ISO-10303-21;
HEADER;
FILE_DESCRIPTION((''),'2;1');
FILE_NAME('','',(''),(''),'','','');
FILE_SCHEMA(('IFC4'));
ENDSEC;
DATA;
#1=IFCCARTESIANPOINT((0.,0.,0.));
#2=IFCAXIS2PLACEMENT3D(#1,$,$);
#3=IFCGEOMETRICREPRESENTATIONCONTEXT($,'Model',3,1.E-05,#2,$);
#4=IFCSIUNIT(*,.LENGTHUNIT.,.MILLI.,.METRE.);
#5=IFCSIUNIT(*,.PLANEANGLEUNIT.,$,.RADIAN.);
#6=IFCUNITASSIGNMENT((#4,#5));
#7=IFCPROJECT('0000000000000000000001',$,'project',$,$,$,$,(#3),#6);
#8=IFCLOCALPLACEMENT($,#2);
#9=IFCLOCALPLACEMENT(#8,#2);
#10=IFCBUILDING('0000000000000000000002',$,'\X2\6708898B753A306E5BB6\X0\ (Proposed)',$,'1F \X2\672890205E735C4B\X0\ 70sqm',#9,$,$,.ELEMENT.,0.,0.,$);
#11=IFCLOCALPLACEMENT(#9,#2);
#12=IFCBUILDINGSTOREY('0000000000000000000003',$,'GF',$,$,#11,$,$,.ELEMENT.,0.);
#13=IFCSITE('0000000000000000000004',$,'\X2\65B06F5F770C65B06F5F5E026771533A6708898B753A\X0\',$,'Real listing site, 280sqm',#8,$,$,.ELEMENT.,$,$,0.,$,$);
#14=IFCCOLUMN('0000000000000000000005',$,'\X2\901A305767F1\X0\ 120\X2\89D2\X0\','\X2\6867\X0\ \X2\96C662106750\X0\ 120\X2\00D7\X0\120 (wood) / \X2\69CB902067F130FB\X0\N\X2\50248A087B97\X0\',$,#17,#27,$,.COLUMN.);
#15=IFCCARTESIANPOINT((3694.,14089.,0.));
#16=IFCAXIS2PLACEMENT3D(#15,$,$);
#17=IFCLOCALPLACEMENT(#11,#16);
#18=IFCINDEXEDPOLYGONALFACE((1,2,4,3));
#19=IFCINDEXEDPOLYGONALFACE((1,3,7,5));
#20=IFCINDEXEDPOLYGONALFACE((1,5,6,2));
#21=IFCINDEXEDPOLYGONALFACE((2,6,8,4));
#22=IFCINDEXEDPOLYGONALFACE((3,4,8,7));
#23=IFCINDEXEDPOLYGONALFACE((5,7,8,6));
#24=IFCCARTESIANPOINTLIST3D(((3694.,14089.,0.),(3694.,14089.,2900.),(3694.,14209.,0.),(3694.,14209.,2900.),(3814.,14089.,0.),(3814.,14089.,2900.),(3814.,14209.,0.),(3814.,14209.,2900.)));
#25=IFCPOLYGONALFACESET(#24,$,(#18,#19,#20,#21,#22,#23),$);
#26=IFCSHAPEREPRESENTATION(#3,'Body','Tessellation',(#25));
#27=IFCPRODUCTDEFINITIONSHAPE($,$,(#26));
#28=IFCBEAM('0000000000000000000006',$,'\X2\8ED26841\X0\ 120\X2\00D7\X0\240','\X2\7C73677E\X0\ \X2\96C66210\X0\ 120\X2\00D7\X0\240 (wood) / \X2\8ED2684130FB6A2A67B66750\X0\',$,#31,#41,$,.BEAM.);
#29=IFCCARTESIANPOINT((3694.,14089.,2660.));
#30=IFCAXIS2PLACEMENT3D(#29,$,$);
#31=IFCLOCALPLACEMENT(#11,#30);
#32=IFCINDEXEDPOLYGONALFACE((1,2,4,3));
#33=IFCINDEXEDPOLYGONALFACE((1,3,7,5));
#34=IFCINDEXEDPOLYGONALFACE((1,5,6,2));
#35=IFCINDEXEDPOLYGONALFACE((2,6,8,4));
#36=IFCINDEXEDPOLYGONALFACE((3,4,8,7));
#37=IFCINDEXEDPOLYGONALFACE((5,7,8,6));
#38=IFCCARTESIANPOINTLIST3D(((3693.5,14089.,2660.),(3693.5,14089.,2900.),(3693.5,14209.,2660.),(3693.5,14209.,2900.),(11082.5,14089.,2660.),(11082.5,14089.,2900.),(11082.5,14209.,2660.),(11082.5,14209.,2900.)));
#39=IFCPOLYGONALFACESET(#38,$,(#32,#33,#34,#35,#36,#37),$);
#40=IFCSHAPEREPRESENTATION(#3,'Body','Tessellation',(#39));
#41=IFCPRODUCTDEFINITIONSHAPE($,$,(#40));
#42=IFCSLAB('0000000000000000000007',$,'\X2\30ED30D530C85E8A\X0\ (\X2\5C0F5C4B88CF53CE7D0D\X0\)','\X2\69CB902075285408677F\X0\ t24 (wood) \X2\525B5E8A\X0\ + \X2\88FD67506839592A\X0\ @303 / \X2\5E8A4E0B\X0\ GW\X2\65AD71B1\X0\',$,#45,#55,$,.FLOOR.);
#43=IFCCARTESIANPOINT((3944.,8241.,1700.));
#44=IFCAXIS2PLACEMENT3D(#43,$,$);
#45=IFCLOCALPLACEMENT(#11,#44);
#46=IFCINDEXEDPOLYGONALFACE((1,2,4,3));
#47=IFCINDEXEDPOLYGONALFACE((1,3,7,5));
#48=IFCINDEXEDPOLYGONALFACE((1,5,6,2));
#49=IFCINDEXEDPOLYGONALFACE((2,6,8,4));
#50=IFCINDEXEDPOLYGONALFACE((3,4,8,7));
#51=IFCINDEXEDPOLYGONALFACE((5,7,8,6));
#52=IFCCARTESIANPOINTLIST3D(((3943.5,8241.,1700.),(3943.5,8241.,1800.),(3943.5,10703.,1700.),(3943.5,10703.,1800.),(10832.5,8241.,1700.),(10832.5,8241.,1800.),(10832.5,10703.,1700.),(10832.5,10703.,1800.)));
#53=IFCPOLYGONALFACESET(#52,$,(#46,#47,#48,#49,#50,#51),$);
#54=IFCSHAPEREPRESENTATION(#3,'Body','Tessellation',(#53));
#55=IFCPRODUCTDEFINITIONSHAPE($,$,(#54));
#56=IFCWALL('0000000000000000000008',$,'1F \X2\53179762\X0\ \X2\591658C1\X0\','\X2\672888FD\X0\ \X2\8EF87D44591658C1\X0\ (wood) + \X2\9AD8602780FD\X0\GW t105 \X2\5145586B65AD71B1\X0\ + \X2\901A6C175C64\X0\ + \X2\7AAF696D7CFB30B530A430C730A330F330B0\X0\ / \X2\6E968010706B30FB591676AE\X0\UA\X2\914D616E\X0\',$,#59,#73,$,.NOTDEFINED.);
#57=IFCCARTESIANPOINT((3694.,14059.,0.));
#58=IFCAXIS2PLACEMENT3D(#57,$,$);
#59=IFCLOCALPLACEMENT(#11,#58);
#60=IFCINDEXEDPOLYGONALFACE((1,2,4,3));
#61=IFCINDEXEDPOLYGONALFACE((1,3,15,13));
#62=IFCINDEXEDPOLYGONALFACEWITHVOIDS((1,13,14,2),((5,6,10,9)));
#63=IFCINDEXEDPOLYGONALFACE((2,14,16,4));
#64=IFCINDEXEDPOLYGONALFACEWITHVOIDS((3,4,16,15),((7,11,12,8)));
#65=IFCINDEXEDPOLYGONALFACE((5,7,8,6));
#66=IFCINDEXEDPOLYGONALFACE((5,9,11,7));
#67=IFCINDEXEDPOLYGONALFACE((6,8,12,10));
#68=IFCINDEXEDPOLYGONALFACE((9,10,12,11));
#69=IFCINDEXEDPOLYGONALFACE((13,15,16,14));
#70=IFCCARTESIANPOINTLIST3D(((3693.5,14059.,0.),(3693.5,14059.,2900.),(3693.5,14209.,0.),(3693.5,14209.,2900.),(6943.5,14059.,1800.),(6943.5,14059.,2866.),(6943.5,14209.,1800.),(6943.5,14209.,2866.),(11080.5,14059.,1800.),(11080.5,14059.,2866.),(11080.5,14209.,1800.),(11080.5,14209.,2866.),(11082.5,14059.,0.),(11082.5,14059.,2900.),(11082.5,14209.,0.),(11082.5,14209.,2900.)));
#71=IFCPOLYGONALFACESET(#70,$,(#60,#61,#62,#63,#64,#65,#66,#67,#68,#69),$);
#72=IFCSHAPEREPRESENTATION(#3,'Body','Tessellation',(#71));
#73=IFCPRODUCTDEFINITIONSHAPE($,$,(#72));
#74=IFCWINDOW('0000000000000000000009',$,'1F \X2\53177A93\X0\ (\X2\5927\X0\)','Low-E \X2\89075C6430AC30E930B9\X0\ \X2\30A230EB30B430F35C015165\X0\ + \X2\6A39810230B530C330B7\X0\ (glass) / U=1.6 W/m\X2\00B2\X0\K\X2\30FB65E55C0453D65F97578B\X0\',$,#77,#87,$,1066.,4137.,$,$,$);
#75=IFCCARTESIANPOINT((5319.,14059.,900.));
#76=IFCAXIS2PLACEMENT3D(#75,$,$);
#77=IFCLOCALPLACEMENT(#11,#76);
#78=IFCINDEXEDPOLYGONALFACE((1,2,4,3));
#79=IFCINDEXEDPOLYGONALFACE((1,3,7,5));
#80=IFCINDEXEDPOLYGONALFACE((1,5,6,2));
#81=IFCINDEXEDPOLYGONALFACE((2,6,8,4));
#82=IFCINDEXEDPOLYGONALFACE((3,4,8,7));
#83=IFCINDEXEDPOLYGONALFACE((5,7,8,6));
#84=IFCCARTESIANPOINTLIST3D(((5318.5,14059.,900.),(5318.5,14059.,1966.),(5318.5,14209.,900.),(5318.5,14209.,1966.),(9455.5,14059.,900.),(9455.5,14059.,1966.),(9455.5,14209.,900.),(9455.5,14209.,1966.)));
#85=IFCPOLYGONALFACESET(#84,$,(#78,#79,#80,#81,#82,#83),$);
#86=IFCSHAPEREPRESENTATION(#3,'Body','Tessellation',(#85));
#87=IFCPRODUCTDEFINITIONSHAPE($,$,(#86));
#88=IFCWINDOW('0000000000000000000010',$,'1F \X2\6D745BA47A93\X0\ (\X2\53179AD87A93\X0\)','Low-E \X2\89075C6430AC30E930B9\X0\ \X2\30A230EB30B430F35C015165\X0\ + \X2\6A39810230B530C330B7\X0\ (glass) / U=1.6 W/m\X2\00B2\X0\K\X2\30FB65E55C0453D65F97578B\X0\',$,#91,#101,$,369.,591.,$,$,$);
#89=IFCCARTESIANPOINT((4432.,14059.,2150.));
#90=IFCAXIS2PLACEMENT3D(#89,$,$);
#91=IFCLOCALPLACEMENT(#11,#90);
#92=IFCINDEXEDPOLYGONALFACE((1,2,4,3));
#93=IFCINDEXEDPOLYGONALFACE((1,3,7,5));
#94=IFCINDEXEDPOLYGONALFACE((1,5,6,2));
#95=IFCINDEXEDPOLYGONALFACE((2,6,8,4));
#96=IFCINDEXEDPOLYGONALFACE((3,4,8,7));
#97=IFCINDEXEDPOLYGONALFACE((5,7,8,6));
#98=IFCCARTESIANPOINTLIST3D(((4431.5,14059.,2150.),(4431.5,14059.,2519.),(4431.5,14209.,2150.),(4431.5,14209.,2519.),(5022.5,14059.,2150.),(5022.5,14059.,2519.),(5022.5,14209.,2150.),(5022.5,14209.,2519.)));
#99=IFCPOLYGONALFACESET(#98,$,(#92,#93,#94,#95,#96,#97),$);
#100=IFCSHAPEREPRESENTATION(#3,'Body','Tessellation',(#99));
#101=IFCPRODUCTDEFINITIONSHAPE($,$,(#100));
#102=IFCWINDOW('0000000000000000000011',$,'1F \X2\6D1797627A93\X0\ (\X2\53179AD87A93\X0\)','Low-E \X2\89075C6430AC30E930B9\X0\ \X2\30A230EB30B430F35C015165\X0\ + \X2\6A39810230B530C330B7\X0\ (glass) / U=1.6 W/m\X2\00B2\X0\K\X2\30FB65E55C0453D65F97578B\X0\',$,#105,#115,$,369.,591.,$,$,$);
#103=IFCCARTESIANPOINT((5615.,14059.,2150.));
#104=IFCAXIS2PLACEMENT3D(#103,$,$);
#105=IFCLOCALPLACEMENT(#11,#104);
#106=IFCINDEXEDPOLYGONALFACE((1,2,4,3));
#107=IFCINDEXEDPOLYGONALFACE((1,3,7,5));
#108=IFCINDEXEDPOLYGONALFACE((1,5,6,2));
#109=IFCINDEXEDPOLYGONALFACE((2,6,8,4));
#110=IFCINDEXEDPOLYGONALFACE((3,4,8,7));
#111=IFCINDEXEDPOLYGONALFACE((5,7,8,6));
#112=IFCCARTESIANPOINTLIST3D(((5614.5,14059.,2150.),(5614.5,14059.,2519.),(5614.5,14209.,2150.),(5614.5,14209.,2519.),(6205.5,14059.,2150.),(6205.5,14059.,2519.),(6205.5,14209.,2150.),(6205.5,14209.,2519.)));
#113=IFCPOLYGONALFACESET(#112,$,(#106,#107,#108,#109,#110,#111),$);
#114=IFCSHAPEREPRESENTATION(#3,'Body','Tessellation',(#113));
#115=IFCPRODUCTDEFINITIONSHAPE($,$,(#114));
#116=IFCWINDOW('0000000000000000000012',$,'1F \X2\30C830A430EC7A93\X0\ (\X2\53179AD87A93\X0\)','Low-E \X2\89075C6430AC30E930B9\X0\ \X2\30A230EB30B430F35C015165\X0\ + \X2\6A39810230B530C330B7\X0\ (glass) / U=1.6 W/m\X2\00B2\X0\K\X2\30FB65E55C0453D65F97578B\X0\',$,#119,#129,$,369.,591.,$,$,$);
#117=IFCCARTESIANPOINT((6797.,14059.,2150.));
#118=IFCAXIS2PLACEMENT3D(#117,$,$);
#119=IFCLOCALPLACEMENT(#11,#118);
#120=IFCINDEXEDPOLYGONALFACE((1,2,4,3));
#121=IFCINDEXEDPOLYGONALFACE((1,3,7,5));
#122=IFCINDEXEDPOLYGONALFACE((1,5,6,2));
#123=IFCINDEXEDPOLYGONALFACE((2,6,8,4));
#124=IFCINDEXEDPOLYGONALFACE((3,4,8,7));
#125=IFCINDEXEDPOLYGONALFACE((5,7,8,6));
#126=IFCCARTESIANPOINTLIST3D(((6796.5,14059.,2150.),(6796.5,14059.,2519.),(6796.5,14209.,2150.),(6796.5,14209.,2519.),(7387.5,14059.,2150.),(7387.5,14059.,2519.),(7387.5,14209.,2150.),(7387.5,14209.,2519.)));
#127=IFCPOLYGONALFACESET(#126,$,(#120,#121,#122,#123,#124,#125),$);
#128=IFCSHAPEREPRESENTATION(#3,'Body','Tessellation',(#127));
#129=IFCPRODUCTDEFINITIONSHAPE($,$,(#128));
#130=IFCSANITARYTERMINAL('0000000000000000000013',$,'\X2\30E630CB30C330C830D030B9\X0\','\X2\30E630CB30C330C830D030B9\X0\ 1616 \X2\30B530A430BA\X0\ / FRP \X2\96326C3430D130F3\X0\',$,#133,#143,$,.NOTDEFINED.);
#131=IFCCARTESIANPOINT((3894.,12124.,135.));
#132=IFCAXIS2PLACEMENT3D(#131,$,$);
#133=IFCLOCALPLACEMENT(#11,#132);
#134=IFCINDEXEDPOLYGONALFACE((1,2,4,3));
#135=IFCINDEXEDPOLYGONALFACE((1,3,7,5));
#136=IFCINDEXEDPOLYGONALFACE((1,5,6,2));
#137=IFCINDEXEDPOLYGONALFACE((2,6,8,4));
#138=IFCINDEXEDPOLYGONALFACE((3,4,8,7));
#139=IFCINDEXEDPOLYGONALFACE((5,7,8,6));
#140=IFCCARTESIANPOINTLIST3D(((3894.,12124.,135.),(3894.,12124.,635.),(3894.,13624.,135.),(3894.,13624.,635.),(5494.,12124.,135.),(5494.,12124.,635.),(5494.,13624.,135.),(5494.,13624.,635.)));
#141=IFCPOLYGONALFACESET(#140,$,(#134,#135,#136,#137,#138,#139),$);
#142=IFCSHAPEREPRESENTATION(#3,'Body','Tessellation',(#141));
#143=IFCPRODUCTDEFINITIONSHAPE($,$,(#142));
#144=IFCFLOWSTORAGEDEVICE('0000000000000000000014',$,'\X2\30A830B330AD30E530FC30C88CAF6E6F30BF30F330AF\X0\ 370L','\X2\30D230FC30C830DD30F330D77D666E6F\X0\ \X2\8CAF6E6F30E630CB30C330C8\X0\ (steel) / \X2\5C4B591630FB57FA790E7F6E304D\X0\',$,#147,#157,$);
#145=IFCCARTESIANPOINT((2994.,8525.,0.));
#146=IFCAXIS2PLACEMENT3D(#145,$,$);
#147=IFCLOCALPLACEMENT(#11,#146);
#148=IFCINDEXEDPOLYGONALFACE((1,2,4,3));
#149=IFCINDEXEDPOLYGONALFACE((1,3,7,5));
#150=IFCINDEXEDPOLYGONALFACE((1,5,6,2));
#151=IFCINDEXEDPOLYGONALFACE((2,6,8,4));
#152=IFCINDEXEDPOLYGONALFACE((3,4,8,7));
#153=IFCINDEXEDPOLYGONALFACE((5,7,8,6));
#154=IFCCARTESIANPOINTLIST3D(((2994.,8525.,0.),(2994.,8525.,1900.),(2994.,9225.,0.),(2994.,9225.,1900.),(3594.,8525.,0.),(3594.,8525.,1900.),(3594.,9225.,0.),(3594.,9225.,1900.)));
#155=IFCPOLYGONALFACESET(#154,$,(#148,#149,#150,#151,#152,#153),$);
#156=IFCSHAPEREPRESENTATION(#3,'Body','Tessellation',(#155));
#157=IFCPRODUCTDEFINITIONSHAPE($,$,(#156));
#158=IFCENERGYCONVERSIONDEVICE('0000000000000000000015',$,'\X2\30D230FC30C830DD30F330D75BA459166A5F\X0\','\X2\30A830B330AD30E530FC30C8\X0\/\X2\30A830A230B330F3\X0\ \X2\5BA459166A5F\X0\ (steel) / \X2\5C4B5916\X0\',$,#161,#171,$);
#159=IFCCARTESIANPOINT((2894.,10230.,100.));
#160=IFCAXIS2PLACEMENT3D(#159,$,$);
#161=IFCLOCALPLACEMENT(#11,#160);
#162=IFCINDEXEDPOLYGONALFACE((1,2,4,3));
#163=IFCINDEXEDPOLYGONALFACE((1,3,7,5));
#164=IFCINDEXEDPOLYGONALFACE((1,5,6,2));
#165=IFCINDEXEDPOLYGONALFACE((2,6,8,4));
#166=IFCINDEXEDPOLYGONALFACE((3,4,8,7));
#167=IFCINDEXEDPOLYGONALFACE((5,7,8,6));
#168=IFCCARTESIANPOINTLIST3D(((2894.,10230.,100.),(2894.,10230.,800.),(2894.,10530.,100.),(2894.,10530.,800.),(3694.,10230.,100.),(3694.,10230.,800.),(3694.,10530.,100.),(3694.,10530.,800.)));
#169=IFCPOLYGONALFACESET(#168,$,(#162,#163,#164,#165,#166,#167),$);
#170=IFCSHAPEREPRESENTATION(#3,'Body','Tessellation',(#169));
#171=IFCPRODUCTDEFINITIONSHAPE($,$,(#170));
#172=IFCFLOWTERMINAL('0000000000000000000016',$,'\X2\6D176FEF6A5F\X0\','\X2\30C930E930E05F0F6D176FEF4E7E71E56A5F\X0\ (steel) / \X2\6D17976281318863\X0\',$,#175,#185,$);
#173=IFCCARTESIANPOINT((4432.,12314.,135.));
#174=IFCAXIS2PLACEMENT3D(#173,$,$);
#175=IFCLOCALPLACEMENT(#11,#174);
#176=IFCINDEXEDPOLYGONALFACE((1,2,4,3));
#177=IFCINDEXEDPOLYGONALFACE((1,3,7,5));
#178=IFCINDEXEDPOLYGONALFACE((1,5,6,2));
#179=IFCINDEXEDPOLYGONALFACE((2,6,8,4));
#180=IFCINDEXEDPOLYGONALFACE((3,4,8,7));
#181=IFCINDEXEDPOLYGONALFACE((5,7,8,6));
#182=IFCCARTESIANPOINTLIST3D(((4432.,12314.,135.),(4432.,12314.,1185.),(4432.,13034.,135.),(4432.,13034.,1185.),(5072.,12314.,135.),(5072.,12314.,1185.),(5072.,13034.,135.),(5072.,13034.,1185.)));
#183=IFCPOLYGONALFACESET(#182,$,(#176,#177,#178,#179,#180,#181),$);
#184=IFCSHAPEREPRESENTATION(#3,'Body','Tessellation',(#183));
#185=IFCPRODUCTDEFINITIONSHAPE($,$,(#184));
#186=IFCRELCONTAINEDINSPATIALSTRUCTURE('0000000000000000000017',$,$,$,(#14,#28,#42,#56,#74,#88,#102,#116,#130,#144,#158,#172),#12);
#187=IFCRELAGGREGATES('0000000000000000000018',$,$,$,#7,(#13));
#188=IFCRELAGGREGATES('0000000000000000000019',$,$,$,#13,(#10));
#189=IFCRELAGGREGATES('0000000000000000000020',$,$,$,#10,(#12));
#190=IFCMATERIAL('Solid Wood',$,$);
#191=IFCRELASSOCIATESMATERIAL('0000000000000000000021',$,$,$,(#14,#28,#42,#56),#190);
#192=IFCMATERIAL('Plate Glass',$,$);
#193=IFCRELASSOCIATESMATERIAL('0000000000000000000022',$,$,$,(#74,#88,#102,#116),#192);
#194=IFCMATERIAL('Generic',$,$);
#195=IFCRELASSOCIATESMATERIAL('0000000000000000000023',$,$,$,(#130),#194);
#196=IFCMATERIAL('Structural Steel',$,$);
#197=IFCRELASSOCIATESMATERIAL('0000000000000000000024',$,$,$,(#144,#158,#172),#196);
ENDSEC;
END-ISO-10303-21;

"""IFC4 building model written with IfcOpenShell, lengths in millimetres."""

from ifc_helpers import new_model, si_unit, frame, frame_2d, origin, place, context, project, spatial, rectangle, extrude, material, element, fill, save


model = new_model("IFC4")

# Units and contexts
model_context = context("Model", 3, precision=1e-05, world=origin())
ifc_project = project(units=[si_unit("LENGTHUNIT", "METRE", prefix="MILLI"), si_unit("PLANEANGLEUNIT", "RADIAN")], contexts=[model_context])

# Site, building, storey
site_placement = place(None, origin())
site = spatial("IfcSite", under=ifc_project, at=site_placement, Name="新潟県新潟市東区月見町", ObjectType="Real listing site, 280sqm", CompositionType="ELEMENT", RefElevation=0.0)
building_placement = place(site_placement, origin())
building = spatial("IfcBuilding", under=site, at=building_placement, Name="月見町の家 (Proposed)", ObjectType="1F 木造平屋 70sqm", CompositionType="ELEMENT", ElevationOfRefHeight=0.0, ElevationOfTerrain=0.0)
storey_placement = place(building_placement, origin())
storey = spatial("IfcBuildingStorey", under=building, at=storey_placement, Name="GF", CompositionType="ELEMENT", Elevation=0.0)

# Column
ifc_material_1 = material(Name="Solid Wood")
column_1_placement = place(storey_placement, frame((3694.0, 14089.0, 0.0)))
element("IfcColumn", 1, at=column_1_placement, inside=storey, material=ifc_material_1, Name="通し柱 120角", Description="桧 集成材 120×120 (wood) / 構造柱・N値計算", PredefinedType="COLUMN", context=model_context, shape_type="SweptSolid", body=[
    extrude(rectangle(XDim=120.0, YDim=120.0, at=frame_2d((60.0, 60.0))), frame((3694.0, 14089.0, 0.0)), (0.0, 0.0, 1.0), 2900.0),
])

# Beam
beam_1_placement = place(storey_placement, frame((3694.0, 14089.0, 2660.0)))
element("IfcBeam", 2, at=beam_1_placement, inside=storey, material=ifc_material_1, Name="軒桁 120×240", Description="米松 集成 120×240 (wood) / 軒桁・横架材", PredefinedType="BEAM", context=model_context, shape_type="SweptSolid", body=[
    extrude(rectangle(XDim=7389.0, YDim=120.0, at=frame_2d((3694.0, 60.0))), frame((3694.0, 14089.0, 2660.0)), (0.0, 0.0, 1.0), 240.0),
])

# Slab
slab_placement = place(storey_placement, frame((3944.0, 8241.0, 1700.0)))
element("IfcSlab", 3, at=slab_placement, inside=storey, material=ifc_material_1, Name="ロフト床 (小屋裏収納)", Description="構造用合板 t24 (wood) 剛床 + 製材根太 @303 / 床下 GW断熱", PredefinedType="FLOOR", context=model_context, shape_type="SweptSolid", body=[
    extrude(rectangle(XDim=6889.0, YDim=2462.0, at=frame_2d((3444.0, 1231.0))), frame((3944.0, 8241.0, 1700.0)), (0.0, 0.0, 1.0), 100.0),
])

# Wall, openings, windows
wall_1_placement = place(storey_placement, frame((3694.0, 14059.0, 0.0)))
wall_1 = element("IfcWall", 4, at=wall_1_placement, inside=storey, material=ifc_material_1, Name="1F 北面 外壁", Description="木製 軸組外壁 (wood) + 高性能GW t105 充填断熱 + 通気層 + 窯業系サイディング / 準耐火・外皮UA配慮", PredefinedType="NOTDEFINED", context=model_context, shape_type="SweptSolid", body=[
    extrude(rectangle(XDim=7389.0, YDim=150.0, at=frame_2d((3694.0, 75.0))), frame((3694.0, 14059.0, 0.0)), (0.0, 0.0, 1.0), 2900.0),
])
opening_1_placement = place(storey_placement, frame((5319.0, 14059.0, 900.0)))
opening_1 = element("IfcOpeningElement", 5, at=opening_1_placement, cuts=wall_1, PredefinedType="NOTDEFINED", context=model_context, shape_type="SweptSolid", body=[
    extrude(rectangle(XDim=4137.0, YDim=150.0, at=frame_2d((2068.0, 75.0))), frame((5319.0, 14059.0, 900.0)), (0.0, 0.0, 1.0), 1066.0),
])
opening_2_placement = place(storey_placement, frame((4432.0, 14059.0, 2150.0)))
opening_2 = element("IfcOpeningElement", 6, at=opening_2_placement, cuts=wall_1, PredefinedType="NOTDEFINED", context=model_context, shape_type="SweptSolid", body=[
    extrude(rectangle(XDim=591.0, YDim=150.0, at=frame_2d((295.0, 75.0))), frame((4432.0, 14059.0, 2150.0)), (0.0, 0.0, 1.0), 369.0),
])
opening_3_placement = place(storey_placement, frame((5615.0, 14059.0, 2150.0)))
opening_3 = element("IfcOpeningElement", 7, at=opening_3_placement, cuts=wall_1, PredefinedType="NOTDEFINED", context=model_context, shape_type="SweptSolid", body=[
    extrude(rectangle(XDim=591.0, YDim=150.0, at=frame_2d((295.0, 75.0))), frame((5615.0, 14059.0, 2150.0)), (0.0, 0.0, 1.0), 369.0),
])
opening_4_placement = place(storey_placement, frame((6797.0, 14059.0, 2150.0)))
opening_4 = element("IfcOpeningElement", 8, at=opening_4_placement, cuts=wall_1, PredefinedType="NOTDEFINED", context=model_context, shape_type="SweptSolid", body=[
    extrude(rectangle(XDim=591.0, YDim=150.0, at=frame_2d((295.0, 75.0))), frame((6797.0, 14059.0, 2150.0)), (0.0, 0.0, 1.0), 369.0),
])
ifc_material_2 = material(Name="Plate Glass")
window_1_placement = place(storey_placement, frame((5319.0, 14059.0, 900.0)))
window_1 = element("IfcWindow", 9, at=window_1_placement, inside=storey, material=ifc_material_2, Name="1F 北窓 (大)", Description="Low-E 複層ガラス アルゴン封入 + 樹脂サッシ (glass) / U=1.6 W/m²K・日射取得型", OverallHeight=1066.0, OverallWidth=4137.0, context=model_context, shape_type="SweptSolid", body=[
    extrude(rectangle(XDim=4137.0, YDim=150.0, at=frame_2d((2068.0, 75.0))), frame((5319.0, 14059.0, 900.0)), (0.0, 0.0, 1.0), 1066.0),
])
fill(opening_1, window_1)
window_2_placement = place(storey_placement, frame((4432.0, 14059.0, 2150.0)))
window_2 = element("IfcWindow", 10, at=window_2_placement, inside=storey, material=ifc_material_2, Name="1F 浴室窓 (北高窓)", Description="Low-E 複層ガラス アルゴン封入 + 樹脂サッシ (glass) / U=1.6 W/m²K・日射取得型", OverallHeight=369.0, OverallWidth=591.0, context=model_context, shape_type="SweptSolid", body=[
    extrude(rectangle(XDim=591.0, YDim=150.0, at=frame_2d((295.0, 75.0))), frame((4432.0, 14059.0, 2150.0)), (0.0, 0.0, 1.0), 369.0),
])
fill(opening_2, window_2)
window_3_placement = place(storey_placement, frame((5615.0, 14059.0, 2150.0)))
window_3 = element("IfcWindow", 11, at=window_3_placement, inside=storey, material=ifc_material_2, Name="1F 洗面窓 (北高窓)", Description="Low-E 複層ガラス アルゴン封入 + 樹脂サッシ (glass) / U=1.6 W/m²K・日射取得型", OverallHeight=369.0, OverallWidth=591.0, context=model_context, shape_type="SweptSolid", body=[
    extrude(rectangle(XDim=591.0, YDim=150.0, at=frame_2d((295.0, 75.0))), frame((5615.0, 14059.0, 2150.0)), (0.0, 0.0, 1.0), 369.0),
])
fill(opening_3, window_3)
window_4_placement = place(storey_placement, frame((6797.0, 14059.0, 2150.0)))
window_4 = element("IfcWindow", 12, at=window_4_placement, inside=storey, material=ifc_material_2, Name="1F トイレ窓 (北高窓)", Description="Low-E 複層ガラス アルゴン封入 + 樹脂サッシ (glass) / U=1.6 W/m²K・日射取得型", OverallHeight=369.0, OverallWidth=591.0, context=model_context, shape_type="SweptSolid", body=[
    extrude(rectangle(XDim=591.0, YDim=150.0, at=frame_2d((295.0, 75.0))), frame((6797.0, 14059.0, 2150.0)), (0.0, 0.0, 1.0), 369.0),
])
fill(opening_4, window_4)

# Shared definitions
ifc_material_3 = material(Name="Structural Steel")

# Sanitary terminal
ifc_material_4 = material(Name="Generic")
sanitary_terminal_placement = place(storey_placement, frame((3894.0, 12124.0, 135.0)))
element("IfcSanitaryTerminal", 13, at=sanitary_terminal_placement, inside=storey, material=ifc_material_4, Name="ユニットバス", Description="ユニットバス 1616 サイズ / FRP 防水パン", PredefinedType="NOTDEFINED", context=model_context, shape_type="SweptSolid", body=[
    extrude(rectangle(XDim=1600.0, YDim=1500.0, at=frame_2d((800.0, 750.0))), frame((3894.0, 12124.0, 135.0)), (0.0, 0.0, 1.0), 500.0),
])

# Flow storage device
flow_storage_device_placement = place(storey_placement, frame((2994.0, 8525.0, 0.0)))
element("IfcFlowStorageDevice", 14, at=flow_storage_device_placement, inside=storey, material=ifc_material_3, Name="エコキュート貯湯タンク 370L", Description="ヒートポンプ給湯 貯湯ユニット (steel) / 屋外・基礎置き", context=model_context, shape_type="SweptSolid", body=[
    extrude(rectangle(XDim=600.0, YDim=700.0, at=frame_2d((300.0, 350.0))), frame((2994.0, 8525.0, 0.0)), (0.0, 0.0, 1.0), 1900.0),
])

# Energy conversion device
energy_conversion_device_placement = place(storey_placement, frame((2894.0, 10230.0, 100.0)))
element("IfcEnergyConversionDevice", 15, at=energy_conversion_device_placement, inside=storey, material=ifc_material_3, Name="ヒートポンプ室外機", Description="エコキュート/エアコン 室外機 (steel) / 屋外", context=model_context, shape_type="SweptSolid", body=[
    extrude(rectangle(XDim=800.0, YDim=300.0, at=frame_2d((400.0, 150.0))), frame((2894.0, 10230.0, 100.0)), (0.0, 0.0, 1.0), 700.0),
])

# Flow terminal
flow_terminal_placement = place(storey_placement, frame((4432.0, 12314.0, 135.0)))
element("IfcFlowTerminal", 16, at=flow_terminal_placement, inside=storey, material=ifc_material_3, Name="洗濯機", Description="ドラム式洗濯乾燥機 (steel) / 洗面脱衣", context=model_context, shape_type="SweptSolid", body=[
    extrude(rectangle(XDim=640.0, YDim=720.0, at=frame_2d((320.0, 360.0))), frame((4432.0, 12314.0, 135.0)), (0.0, 0.0, 1.0), 1050.0),
])

save(model, "model.ifc")
